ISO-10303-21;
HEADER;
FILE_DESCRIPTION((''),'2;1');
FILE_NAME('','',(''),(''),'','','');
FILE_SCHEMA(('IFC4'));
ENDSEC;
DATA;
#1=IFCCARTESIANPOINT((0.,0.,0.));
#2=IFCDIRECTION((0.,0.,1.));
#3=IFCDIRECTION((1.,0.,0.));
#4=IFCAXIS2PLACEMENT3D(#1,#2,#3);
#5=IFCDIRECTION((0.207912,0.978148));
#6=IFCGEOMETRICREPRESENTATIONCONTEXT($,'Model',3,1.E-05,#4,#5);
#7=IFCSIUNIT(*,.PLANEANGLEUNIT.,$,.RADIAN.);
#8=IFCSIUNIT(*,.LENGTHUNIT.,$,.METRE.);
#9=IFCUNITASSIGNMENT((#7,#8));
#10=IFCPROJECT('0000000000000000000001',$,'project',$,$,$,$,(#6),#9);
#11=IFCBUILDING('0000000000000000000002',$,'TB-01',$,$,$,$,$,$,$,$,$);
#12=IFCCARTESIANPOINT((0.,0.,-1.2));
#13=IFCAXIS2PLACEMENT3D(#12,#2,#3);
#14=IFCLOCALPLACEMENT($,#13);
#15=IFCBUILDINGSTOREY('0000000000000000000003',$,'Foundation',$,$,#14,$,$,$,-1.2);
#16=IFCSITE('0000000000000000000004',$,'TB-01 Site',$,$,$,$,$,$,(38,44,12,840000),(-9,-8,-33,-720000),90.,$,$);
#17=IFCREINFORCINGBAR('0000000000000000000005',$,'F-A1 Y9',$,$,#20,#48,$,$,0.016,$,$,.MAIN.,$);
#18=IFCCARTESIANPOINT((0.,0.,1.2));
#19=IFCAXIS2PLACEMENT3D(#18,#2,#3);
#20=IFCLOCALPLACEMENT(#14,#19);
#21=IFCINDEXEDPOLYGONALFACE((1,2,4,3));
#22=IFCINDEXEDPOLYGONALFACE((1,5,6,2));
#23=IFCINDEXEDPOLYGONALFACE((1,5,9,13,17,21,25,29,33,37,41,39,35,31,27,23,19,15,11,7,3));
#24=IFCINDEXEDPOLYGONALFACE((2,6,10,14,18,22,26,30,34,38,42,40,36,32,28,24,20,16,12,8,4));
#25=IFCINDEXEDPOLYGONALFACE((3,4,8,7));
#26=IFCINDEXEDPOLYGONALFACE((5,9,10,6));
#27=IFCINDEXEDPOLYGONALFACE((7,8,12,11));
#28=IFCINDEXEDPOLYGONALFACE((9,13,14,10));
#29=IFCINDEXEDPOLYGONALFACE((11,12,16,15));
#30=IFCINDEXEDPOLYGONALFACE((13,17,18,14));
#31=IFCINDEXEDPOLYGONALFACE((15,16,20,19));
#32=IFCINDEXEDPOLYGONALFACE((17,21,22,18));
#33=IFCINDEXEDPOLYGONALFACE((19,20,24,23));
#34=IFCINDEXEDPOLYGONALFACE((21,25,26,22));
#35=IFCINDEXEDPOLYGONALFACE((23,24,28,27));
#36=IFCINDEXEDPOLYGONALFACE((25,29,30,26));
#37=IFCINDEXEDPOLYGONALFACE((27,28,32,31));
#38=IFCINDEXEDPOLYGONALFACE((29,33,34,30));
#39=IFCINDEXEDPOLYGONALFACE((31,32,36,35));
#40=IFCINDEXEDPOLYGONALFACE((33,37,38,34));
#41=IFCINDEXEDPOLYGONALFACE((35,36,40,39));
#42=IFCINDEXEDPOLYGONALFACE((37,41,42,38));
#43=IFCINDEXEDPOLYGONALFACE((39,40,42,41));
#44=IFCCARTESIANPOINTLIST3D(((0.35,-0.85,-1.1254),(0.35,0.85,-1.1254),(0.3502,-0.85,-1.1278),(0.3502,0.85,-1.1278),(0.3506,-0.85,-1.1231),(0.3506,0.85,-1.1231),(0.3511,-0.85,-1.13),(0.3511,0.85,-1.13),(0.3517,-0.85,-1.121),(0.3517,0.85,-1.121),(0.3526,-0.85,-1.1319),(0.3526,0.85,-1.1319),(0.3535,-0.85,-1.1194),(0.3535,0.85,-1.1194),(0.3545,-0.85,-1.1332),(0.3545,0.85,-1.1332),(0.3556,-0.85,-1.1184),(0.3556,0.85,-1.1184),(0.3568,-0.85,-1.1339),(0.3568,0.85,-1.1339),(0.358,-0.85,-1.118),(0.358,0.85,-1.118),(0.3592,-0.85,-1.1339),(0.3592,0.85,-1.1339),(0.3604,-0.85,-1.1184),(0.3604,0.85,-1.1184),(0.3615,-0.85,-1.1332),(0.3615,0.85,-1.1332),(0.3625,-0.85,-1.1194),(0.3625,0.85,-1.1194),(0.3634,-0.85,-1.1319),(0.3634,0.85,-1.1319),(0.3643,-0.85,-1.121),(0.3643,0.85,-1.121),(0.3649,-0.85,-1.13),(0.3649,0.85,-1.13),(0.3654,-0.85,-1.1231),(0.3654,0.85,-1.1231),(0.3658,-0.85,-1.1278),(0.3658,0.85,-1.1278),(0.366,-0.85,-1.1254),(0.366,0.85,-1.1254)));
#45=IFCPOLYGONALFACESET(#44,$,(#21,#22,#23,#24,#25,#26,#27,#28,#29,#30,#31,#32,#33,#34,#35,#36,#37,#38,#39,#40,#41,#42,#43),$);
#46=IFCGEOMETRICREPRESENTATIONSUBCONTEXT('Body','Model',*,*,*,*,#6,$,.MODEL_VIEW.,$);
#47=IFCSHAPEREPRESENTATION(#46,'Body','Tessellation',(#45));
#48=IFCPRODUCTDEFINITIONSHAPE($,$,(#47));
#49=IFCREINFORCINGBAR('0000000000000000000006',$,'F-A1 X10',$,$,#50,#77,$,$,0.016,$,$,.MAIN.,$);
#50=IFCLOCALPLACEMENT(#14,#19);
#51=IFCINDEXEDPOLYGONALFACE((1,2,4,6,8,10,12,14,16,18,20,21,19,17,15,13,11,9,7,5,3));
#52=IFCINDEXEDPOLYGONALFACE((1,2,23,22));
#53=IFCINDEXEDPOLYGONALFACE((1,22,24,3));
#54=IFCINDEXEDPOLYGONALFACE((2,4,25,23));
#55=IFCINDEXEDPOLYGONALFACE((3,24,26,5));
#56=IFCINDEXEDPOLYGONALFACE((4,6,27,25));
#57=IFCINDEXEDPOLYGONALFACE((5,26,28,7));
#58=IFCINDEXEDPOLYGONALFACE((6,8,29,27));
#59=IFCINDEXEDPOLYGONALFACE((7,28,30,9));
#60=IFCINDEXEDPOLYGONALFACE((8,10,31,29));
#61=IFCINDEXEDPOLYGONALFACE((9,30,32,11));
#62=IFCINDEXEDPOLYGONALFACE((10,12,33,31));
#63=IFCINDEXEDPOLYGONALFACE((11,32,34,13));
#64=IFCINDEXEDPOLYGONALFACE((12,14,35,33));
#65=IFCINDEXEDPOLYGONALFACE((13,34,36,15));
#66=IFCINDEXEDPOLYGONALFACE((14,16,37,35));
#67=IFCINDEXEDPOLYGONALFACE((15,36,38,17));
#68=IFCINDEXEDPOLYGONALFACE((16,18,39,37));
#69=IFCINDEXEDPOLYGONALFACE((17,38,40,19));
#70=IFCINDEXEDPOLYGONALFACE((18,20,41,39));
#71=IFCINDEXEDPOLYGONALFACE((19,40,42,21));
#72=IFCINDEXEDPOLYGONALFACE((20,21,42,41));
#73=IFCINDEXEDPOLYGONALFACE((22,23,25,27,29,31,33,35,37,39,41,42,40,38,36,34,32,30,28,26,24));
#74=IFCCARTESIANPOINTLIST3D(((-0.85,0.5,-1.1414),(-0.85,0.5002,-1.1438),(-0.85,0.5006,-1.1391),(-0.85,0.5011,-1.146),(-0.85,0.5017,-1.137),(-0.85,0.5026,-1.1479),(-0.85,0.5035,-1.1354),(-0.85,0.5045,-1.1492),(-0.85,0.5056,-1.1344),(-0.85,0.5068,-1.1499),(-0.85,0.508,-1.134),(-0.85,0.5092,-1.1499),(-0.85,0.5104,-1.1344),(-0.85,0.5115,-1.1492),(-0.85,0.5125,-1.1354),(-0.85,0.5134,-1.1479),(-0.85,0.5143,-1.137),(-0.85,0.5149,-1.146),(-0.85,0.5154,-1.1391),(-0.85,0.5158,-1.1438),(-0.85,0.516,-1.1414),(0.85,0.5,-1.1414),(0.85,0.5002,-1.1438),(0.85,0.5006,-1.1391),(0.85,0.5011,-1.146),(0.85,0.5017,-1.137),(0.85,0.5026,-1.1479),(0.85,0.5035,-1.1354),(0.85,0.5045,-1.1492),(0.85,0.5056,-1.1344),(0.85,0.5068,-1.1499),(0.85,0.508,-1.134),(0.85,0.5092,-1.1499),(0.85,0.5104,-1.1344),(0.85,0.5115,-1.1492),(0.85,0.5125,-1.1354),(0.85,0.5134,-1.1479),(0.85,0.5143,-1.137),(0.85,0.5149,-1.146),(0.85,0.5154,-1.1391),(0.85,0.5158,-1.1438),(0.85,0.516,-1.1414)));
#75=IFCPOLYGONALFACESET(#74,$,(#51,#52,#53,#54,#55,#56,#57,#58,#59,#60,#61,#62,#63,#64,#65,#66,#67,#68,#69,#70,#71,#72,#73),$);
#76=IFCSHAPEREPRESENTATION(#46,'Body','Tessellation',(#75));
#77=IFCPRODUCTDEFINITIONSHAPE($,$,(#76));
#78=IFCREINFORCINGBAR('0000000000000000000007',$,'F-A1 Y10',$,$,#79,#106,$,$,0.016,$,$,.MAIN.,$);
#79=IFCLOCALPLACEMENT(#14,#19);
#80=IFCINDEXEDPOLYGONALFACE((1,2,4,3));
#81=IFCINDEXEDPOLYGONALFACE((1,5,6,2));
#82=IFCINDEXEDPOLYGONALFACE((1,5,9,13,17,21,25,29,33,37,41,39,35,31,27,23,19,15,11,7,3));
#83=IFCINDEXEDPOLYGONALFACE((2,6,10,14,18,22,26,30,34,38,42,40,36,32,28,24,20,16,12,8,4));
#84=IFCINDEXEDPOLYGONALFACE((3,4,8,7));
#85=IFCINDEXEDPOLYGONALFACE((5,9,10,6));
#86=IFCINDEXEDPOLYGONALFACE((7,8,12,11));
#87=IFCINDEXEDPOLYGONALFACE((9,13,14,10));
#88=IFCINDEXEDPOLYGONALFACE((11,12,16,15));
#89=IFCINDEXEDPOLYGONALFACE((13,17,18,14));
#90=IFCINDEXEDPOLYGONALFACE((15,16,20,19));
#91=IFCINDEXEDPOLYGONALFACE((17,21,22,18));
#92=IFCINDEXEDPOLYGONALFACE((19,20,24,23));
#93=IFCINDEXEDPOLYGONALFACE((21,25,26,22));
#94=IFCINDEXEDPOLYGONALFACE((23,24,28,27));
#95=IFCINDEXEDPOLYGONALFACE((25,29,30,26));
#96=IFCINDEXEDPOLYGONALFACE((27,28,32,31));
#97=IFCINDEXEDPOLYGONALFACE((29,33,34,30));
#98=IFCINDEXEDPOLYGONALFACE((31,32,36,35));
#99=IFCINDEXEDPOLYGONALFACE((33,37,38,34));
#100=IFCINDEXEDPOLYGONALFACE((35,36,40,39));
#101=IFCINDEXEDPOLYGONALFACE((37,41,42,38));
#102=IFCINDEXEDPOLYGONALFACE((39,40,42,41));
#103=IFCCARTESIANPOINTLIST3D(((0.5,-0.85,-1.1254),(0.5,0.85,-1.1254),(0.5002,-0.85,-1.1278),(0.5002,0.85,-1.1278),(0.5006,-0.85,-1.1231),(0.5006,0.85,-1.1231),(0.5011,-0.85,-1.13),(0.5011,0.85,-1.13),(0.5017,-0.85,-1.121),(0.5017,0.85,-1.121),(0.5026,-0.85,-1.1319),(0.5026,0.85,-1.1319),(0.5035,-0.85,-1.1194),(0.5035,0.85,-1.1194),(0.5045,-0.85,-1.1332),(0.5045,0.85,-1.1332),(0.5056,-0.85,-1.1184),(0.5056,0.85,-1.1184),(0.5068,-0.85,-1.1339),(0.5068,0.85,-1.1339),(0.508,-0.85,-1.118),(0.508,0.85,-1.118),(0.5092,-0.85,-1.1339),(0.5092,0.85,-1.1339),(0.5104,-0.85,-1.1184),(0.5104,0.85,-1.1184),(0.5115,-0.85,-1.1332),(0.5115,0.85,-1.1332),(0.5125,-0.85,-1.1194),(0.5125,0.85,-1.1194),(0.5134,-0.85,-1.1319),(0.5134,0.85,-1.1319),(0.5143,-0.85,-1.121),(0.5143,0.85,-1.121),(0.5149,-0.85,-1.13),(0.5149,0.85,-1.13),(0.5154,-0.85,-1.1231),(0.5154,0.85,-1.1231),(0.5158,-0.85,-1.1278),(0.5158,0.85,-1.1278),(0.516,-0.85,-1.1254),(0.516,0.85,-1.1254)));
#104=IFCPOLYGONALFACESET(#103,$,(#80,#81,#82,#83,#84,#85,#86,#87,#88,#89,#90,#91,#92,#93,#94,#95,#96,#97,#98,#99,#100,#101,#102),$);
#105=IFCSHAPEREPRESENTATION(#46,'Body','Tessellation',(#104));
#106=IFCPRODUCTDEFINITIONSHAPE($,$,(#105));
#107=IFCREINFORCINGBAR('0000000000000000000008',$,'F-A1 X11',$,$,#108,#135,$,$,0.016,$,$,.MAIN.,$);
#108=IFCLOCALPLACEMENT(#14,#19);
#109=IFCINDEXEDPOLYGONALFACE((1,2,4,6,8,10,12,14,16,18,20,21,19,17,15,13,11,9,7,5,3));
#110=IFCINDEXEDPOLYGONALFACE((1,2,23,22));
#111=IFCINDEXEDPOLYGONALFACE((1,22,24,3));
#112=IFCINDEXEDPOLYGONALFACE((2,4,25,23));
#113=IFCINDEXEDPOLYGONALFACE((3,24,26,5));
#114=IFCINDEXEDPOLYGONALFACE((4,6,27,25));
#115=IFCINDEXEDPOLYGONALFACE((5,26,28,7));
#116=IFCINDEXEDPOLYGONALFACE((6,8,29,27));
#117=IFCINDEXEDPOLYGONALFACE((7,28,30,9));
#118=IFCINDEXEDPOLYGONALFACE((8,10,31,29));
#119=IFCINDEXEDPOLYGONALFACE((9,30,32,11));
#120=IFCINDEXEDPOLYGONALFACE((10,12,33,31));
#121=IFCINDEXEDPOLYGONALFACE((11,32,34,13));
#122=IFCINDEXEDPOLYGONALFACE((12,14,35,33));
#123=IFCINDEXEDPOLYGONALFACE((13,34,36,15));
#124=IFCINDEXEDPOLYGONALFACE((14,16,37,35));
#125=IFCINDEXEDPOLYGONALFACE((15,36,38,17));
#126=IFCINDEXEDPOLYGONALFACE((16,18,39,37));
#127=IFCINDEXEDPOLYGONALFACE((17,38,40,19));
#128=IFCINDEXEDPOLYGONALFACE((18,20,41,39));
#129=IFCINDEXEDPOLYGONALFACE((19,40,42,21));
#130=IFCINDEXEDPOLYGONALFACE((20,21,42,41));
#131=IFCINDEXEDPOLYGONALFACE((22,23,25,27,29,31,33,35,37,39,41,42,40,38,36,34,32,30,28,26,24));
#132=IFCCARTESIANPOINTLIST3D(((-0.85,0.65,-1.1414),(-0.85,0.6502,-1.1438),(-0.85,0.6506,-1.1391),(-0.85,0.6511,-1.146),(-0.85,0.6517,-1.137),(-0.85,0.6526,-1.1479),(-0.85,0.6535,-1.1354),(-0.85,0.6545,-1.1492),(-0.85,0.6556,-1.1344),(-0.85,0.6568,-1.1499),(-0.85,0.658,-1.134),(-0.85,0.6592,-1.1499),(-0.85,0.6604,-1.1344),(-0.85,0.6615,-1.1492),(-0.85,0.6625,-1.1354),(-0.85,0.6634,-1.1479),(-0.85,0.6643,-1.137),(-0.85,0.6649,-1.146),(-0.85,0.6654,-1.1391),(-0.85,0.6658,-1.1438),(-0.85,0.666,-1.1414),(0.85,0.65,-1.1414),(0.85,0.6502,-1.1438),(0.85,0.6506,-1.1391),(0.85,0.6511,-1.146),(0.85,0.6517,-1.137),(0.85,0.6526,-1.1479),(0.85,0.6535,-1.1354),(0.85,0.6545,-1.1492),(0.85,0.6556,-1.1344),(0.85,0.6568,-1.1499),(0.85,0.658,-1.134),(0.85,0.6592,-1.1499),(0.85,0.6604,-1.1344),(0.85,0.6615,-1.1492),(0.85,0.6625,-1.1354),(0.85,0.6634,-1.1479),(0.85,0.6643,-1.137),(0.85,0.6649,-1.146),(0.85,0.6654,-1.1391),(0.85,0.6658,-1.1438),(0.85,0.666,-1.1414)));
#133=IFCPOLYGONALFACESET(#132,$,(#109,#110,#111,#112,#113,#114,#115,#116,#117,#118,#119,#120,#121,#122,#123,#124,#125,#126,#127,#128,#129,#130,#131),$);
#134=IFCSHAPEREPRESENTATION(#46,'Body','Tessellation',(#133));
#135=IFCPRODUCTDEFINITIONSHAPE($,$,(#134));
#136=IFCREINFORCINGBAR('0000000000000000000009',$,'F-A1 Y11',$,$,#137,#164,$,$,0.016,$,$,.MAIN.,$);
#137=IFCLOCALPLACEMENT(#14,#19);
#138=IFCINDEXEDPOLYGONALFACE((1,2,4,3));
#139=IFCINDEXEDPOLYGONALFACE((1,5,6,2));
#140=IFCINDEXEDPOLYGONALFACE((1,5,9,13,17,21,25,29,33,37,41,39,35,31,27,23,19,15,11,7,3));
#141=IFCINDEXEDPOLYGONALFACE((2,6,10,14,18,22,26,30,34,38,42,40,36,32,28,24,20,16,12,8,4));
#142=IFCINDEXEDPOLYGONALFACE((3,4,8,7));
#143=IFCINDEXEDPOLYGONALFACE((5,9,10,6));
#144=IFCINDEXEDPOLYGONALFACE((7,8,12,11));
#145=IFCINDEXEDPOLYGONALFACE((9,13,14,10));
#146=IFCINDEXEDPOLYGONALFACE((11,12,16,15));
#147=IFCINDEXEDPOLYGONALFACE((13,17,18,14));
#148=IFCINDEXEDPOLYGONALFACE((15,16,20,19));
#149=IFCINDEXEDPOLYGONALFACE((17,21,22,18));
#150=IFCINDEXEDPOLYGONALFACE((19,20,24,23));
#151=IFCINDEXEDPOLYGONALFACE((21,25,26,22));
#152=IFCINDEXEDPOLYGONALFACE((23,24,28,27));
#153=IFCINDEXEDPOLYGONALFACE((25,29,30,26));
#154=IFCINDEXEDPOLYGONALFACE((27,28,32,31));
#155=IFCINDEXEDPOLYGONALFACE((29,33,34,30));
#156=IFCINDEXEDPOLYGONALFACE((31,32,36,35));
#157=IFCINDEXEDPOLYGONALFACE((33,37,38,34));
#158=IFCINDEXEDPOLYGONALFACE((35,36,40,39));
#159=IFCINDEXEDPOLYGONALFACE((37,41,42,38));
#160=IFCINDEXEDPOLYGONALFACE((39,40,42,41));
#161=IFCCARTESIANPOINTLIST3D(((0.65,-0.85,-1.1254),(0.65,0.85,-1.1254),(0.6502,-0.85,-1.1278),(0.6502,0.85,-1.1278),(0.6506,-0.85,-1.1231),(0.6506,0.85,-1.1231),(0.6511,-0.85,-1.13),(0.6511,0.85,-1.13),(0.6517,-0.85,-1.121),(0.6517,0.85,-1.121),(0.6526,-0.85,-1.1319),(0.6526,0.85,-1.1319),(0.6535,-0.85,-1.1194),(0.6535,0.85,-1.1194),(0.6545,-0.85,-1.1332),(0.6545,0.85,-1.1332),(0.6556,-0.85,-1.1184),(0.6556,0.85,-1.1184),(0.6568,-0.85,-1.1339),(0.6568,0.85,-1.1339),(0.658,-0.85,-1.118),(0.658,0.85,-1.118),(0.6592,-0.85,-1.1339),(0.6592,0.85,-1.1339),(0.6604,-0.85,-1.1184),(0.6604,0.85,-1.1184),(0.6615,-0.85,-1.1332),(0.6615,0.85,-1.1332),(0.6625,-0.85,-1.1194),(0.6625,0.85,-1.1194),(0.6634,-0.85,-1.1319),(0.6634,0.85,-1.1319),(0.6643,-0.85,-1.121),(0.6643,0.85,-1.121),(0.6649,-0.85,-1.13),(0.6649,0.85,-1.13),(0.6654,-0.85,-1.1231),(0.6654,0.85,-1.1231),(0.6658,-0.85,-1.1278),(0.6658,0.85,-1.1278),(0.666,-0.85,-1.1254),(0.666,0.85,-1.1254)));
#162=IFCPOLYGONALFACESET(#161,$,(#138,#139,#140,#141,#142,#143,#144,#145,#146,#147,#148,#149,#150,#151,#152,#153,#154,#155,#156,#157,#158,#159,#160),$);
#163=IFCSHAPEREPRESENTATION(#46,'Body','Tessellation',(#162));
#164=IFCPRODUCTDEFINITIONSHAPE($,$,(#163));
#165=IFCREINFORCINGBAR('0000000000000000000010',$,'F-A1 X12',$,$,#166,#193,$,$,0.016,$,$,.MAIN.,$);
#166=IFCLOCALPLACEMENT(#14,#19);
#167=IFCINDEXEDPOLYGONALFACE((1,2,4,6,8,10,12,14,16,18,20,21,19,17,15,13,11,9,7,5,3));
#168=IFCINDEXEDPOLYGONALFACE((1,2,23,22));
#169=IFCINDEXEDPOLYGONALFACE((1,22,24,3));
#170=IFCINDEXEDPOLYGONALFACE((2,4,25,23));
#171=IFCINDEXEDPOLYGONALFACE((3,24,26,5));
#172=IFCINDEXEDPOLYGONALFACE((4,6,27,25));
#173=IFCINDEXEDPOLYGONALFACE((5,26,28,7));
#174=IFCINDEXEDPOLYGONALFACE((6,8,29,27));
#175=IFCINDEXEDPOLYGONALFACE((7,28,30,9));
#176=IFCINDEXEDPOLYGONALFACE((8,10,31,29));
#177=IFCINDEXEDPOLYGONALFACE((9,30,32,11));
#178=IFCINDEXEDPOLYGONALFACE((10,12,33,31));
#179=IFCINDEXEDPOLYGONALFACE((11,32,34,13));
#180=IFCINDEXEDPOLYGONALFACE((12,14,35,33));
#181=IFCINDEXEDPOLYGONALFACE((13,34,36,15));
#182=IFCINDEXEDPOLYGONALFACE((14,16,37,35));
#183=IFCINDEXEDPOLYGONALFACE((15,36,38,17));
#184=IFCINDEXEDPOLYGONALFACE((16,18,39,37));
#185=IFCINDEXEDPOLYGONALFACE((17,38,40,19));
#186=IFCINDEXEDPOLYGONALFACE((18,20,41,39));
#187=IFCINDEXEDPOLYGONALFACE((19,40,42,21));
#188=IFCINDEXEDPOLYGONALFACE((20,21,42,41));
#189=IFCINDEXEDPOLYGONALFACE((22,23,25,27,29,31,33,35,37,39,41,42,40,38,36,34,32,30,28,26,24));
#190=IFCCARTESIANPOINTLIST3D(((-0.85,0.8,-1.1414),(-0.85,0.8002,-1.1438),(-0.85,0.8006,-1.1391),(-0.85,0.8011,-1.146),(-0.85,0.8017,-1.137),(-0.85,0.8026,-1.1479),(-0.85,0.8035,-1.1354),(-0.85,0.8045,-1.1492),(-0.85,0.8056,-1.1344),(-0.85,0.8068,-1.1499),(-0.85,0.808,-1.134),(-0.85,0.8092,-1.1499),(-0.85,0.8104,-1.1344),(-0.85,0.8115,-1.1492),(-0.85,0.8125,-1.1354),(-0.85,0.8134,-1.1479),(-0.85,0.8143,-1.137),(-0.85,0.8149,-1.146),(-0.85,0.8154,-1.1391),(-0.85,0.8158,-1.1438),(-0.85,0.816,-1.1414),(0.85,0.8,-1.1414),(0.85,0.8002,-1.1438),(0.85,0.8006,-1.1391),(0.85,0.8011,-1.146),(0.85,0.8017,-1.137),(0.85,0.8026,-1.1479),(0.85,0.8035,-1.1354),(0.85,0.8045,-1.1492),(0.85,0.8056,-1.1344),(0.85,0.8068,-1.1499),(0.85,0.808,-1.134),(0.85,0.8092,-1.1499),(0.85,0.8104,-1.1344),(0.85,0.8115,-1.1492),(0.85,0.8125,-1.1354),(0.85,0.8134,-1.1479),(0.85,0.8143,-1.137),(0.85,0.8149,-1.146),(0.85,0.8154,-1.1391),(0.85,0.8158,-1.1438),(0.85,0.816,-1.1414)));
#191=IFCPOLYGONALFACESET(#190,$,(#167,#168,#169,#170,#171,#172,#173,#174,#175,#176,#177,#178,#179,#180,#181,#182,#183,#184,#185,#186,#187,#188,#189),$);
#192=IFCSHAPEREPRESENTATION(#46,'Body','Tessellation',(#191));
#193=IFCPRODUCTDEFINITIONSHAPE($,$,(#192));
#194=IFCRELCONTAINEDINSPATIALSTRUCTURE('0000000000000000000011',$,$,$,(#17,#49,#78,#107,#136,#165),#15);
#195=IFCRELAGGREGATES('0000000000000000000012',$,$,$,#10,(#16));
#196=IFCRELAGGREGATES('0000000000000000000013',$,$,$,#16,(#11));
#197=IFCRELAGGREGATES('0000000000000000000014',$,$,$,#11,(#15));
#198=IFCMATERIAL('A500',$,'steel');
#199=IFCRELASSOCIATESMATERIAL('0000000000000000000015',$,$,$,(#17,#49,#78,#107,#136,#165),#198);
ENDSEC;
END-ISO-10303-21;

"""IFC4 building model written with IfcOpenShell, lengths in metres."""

from ifc_helpers import new_model, entity, si_unit, direction, frame, origin_with_axes, place, context, subcontext, project, spatial, material, element, save


model = new_model("IFC4")

# Units and contexts
model_context = context("Model", 3, precision=1e-05, world=origin_with_axes(), true_north=direction((0.207912, 0.978148)))
body_context = subcontext(model_context, "Body", "Model", "MODEL_VIEW")
ifc_project = project(units=[si_unit("PLANEANGLEUNIT", "RADIAN"), si_unit("LENGTHUNIT", "METRE")], contexts=[model_context])

# Site, building, storey
site = spatial("IfcSite", under=ifc_project, Name="TB-01 Site", RefLatitude=(38, 44, 12, 840000), RefLongitude=(-9, -8, -33, -720000), RefElevation=90.0)
building = spatial("IfcBuilding", under=site, Name="TB-01")
storey_placement = place(None, frame((0.0, 0.0, -1.2), z_axis=(0.0, 0.0, 1.0), x_axis=(1.0, 0.0, 0.0)))
storey = spatial("IfcBuildingStorey", under=building, at=storey_placement, Name="Foundation", Elevation=-1.2)

# Reinforcing bars
ifc_material_1 = material(Name="A500", Category="steel")
reinforcing_bar_1_placement = place(storey_placement, frame((0.0, 0.0, 1.2), z_axis=(0.0, 0.0, 1.0), x_axis=(1.0, 0.0, 0.0)))
element("IfcReinforcingBar", 1, at=reinforcing_bar_1_placement, inside=storey, material=ifc_material_1, Name="F-A1 Y9", NominalDiameter=0.016, PredefinedType="MAIN", context=body_context, shape_type="AdvancedSweptSolid", body=[
    entity("IfcSweptDiskSolid", entity("IfcPolyline", [entity("IfcCartesianPoint", [0.358, -0.85, -1.126]), entity("IfcCartesianPoint", [0.358, 0.85, -1.126])]), 0.008),
])
reinforcing_bar_2_placement = place(storey_placement, frame((0.0, 0.0, 1.2), z_axis=(0.0, 0.0, 1.0), x_axis=(1.0, 0.0, 0.0)))
element("IfcReinforcingBar", 2, at=reinforcing_bar_2_placement, inside=storey, material=ifc_material_1, Name="F-A1 X10", NominalDiameter=0.016, PredefinedType="MAIN", context=body_context, shape_type="AdvancedSweptSolid", body=[
    entity("IfcSweptDiskSolid", entity("IfcPolyline", [entity("IfcCartesianPoint", [-0.85, 0.508, -1.142]), entity("IfcCartesianPoint", [0.85, 0.508, -1.142])]), 0.008),
])
reinforcing_bar_3_placement = place(storey_placement, frame((0.0, 0.0, 1.2), z_axis=(0.0, 0.0, 1.0), x_axis=(1.0, 0.0, 0.0)))
element("IfcReinforcingBar", 3, at=reinforcing_bar_3_placement, inside=storey, material=ifc_material_1, Name="F-A1 Y10", NominalDiameter=0.016, PredefinedType="MAIN", context=body_context, shape_type="AdvancedSweptSolid", body=[
    entity("IfcSweptDiskSolid", entity("IfcPolyline", [entity("IfcCartesianPoint", [0.508, -0.85, -1.126]), entity("IfcCartesianPoint", [0.508, 0.85, -1.126])]), 0.008),
])
reinforcing_bar_4_placement = place(storey_placement, frame((0.0, 0.0, 1.2), z_axis=(0.0, 0.0, 1.0), x_axis=(1.0, 0.0, 0.0)))
element("IfcReinforcingBar", 4, at=reinforcing_bar_4_placement, inside=storey, material=ifc_material_1, Name="F-A1 X11", NominalDiameter=0.016, PredefinedType="MAIN", context=body_context, shape_type="AdvancedSweptSolid", body=[
    entity("IfcSweptDiskSolid", entity("IfcPolyline", [entity("IfcCartesianPoint", [-0.85, 0.658, -1.142]), entity("IfcCartesianPoint", [0.85, 0.658, -1.142])]), 0.008),
])
reinforcing_bar_5_placement = place(storey_placement, frame((0.0, 0.0, 1.2), z_axis=(0.0, 0.0, 1.0), x_axis=(1.0, 0.0, 0.0)))
element("IfcReinforcingBar", 5, at=reinforcing_bar_5_placement, inside=storey, material=ifc_material_1, Name="F-A1 Y11", NominalDiameter=0.016, PredefinedType="MAIN", context=body_context, shape_type="AdvancedSweptSolid", body=[
    entity("IfcSweptDiskSolid", entity("IfcPolyline", [entity("IfcCartesianPoint", [0.658, -0.85, -1.126]), entity("IfcCartesianPoint", [0.658, 0.85, -1.126])]), 0.008),
])
reinforcing_bar_6_placement = place(storey_placement, frame((0.0, 0.0, 1.2), z_axis=(0.0, 0.0, 1.0), x_axis=(1.0, 0.0, 0.0)))
element("IfcReinforcingBar", 6, at=reinforcing_bar_6_placement, inside=storey, material=ifc_material_1, Name="F-A1 X12", NominalDiameter=0.016, PredefinedType="MAIN", context=body_context, shape_type="AdvancedSweptSolid", body=[
    entity("IfcSweptDiskSolid", entity("IfcPolyline", [entity("IfcCartesianPoint", [-0.85, 0.808, -1.142]), entity("IfcCartesianPoint", [0.85, 0.808, -1.142])]), 0.008),
])

save(model, "model.ifc")
